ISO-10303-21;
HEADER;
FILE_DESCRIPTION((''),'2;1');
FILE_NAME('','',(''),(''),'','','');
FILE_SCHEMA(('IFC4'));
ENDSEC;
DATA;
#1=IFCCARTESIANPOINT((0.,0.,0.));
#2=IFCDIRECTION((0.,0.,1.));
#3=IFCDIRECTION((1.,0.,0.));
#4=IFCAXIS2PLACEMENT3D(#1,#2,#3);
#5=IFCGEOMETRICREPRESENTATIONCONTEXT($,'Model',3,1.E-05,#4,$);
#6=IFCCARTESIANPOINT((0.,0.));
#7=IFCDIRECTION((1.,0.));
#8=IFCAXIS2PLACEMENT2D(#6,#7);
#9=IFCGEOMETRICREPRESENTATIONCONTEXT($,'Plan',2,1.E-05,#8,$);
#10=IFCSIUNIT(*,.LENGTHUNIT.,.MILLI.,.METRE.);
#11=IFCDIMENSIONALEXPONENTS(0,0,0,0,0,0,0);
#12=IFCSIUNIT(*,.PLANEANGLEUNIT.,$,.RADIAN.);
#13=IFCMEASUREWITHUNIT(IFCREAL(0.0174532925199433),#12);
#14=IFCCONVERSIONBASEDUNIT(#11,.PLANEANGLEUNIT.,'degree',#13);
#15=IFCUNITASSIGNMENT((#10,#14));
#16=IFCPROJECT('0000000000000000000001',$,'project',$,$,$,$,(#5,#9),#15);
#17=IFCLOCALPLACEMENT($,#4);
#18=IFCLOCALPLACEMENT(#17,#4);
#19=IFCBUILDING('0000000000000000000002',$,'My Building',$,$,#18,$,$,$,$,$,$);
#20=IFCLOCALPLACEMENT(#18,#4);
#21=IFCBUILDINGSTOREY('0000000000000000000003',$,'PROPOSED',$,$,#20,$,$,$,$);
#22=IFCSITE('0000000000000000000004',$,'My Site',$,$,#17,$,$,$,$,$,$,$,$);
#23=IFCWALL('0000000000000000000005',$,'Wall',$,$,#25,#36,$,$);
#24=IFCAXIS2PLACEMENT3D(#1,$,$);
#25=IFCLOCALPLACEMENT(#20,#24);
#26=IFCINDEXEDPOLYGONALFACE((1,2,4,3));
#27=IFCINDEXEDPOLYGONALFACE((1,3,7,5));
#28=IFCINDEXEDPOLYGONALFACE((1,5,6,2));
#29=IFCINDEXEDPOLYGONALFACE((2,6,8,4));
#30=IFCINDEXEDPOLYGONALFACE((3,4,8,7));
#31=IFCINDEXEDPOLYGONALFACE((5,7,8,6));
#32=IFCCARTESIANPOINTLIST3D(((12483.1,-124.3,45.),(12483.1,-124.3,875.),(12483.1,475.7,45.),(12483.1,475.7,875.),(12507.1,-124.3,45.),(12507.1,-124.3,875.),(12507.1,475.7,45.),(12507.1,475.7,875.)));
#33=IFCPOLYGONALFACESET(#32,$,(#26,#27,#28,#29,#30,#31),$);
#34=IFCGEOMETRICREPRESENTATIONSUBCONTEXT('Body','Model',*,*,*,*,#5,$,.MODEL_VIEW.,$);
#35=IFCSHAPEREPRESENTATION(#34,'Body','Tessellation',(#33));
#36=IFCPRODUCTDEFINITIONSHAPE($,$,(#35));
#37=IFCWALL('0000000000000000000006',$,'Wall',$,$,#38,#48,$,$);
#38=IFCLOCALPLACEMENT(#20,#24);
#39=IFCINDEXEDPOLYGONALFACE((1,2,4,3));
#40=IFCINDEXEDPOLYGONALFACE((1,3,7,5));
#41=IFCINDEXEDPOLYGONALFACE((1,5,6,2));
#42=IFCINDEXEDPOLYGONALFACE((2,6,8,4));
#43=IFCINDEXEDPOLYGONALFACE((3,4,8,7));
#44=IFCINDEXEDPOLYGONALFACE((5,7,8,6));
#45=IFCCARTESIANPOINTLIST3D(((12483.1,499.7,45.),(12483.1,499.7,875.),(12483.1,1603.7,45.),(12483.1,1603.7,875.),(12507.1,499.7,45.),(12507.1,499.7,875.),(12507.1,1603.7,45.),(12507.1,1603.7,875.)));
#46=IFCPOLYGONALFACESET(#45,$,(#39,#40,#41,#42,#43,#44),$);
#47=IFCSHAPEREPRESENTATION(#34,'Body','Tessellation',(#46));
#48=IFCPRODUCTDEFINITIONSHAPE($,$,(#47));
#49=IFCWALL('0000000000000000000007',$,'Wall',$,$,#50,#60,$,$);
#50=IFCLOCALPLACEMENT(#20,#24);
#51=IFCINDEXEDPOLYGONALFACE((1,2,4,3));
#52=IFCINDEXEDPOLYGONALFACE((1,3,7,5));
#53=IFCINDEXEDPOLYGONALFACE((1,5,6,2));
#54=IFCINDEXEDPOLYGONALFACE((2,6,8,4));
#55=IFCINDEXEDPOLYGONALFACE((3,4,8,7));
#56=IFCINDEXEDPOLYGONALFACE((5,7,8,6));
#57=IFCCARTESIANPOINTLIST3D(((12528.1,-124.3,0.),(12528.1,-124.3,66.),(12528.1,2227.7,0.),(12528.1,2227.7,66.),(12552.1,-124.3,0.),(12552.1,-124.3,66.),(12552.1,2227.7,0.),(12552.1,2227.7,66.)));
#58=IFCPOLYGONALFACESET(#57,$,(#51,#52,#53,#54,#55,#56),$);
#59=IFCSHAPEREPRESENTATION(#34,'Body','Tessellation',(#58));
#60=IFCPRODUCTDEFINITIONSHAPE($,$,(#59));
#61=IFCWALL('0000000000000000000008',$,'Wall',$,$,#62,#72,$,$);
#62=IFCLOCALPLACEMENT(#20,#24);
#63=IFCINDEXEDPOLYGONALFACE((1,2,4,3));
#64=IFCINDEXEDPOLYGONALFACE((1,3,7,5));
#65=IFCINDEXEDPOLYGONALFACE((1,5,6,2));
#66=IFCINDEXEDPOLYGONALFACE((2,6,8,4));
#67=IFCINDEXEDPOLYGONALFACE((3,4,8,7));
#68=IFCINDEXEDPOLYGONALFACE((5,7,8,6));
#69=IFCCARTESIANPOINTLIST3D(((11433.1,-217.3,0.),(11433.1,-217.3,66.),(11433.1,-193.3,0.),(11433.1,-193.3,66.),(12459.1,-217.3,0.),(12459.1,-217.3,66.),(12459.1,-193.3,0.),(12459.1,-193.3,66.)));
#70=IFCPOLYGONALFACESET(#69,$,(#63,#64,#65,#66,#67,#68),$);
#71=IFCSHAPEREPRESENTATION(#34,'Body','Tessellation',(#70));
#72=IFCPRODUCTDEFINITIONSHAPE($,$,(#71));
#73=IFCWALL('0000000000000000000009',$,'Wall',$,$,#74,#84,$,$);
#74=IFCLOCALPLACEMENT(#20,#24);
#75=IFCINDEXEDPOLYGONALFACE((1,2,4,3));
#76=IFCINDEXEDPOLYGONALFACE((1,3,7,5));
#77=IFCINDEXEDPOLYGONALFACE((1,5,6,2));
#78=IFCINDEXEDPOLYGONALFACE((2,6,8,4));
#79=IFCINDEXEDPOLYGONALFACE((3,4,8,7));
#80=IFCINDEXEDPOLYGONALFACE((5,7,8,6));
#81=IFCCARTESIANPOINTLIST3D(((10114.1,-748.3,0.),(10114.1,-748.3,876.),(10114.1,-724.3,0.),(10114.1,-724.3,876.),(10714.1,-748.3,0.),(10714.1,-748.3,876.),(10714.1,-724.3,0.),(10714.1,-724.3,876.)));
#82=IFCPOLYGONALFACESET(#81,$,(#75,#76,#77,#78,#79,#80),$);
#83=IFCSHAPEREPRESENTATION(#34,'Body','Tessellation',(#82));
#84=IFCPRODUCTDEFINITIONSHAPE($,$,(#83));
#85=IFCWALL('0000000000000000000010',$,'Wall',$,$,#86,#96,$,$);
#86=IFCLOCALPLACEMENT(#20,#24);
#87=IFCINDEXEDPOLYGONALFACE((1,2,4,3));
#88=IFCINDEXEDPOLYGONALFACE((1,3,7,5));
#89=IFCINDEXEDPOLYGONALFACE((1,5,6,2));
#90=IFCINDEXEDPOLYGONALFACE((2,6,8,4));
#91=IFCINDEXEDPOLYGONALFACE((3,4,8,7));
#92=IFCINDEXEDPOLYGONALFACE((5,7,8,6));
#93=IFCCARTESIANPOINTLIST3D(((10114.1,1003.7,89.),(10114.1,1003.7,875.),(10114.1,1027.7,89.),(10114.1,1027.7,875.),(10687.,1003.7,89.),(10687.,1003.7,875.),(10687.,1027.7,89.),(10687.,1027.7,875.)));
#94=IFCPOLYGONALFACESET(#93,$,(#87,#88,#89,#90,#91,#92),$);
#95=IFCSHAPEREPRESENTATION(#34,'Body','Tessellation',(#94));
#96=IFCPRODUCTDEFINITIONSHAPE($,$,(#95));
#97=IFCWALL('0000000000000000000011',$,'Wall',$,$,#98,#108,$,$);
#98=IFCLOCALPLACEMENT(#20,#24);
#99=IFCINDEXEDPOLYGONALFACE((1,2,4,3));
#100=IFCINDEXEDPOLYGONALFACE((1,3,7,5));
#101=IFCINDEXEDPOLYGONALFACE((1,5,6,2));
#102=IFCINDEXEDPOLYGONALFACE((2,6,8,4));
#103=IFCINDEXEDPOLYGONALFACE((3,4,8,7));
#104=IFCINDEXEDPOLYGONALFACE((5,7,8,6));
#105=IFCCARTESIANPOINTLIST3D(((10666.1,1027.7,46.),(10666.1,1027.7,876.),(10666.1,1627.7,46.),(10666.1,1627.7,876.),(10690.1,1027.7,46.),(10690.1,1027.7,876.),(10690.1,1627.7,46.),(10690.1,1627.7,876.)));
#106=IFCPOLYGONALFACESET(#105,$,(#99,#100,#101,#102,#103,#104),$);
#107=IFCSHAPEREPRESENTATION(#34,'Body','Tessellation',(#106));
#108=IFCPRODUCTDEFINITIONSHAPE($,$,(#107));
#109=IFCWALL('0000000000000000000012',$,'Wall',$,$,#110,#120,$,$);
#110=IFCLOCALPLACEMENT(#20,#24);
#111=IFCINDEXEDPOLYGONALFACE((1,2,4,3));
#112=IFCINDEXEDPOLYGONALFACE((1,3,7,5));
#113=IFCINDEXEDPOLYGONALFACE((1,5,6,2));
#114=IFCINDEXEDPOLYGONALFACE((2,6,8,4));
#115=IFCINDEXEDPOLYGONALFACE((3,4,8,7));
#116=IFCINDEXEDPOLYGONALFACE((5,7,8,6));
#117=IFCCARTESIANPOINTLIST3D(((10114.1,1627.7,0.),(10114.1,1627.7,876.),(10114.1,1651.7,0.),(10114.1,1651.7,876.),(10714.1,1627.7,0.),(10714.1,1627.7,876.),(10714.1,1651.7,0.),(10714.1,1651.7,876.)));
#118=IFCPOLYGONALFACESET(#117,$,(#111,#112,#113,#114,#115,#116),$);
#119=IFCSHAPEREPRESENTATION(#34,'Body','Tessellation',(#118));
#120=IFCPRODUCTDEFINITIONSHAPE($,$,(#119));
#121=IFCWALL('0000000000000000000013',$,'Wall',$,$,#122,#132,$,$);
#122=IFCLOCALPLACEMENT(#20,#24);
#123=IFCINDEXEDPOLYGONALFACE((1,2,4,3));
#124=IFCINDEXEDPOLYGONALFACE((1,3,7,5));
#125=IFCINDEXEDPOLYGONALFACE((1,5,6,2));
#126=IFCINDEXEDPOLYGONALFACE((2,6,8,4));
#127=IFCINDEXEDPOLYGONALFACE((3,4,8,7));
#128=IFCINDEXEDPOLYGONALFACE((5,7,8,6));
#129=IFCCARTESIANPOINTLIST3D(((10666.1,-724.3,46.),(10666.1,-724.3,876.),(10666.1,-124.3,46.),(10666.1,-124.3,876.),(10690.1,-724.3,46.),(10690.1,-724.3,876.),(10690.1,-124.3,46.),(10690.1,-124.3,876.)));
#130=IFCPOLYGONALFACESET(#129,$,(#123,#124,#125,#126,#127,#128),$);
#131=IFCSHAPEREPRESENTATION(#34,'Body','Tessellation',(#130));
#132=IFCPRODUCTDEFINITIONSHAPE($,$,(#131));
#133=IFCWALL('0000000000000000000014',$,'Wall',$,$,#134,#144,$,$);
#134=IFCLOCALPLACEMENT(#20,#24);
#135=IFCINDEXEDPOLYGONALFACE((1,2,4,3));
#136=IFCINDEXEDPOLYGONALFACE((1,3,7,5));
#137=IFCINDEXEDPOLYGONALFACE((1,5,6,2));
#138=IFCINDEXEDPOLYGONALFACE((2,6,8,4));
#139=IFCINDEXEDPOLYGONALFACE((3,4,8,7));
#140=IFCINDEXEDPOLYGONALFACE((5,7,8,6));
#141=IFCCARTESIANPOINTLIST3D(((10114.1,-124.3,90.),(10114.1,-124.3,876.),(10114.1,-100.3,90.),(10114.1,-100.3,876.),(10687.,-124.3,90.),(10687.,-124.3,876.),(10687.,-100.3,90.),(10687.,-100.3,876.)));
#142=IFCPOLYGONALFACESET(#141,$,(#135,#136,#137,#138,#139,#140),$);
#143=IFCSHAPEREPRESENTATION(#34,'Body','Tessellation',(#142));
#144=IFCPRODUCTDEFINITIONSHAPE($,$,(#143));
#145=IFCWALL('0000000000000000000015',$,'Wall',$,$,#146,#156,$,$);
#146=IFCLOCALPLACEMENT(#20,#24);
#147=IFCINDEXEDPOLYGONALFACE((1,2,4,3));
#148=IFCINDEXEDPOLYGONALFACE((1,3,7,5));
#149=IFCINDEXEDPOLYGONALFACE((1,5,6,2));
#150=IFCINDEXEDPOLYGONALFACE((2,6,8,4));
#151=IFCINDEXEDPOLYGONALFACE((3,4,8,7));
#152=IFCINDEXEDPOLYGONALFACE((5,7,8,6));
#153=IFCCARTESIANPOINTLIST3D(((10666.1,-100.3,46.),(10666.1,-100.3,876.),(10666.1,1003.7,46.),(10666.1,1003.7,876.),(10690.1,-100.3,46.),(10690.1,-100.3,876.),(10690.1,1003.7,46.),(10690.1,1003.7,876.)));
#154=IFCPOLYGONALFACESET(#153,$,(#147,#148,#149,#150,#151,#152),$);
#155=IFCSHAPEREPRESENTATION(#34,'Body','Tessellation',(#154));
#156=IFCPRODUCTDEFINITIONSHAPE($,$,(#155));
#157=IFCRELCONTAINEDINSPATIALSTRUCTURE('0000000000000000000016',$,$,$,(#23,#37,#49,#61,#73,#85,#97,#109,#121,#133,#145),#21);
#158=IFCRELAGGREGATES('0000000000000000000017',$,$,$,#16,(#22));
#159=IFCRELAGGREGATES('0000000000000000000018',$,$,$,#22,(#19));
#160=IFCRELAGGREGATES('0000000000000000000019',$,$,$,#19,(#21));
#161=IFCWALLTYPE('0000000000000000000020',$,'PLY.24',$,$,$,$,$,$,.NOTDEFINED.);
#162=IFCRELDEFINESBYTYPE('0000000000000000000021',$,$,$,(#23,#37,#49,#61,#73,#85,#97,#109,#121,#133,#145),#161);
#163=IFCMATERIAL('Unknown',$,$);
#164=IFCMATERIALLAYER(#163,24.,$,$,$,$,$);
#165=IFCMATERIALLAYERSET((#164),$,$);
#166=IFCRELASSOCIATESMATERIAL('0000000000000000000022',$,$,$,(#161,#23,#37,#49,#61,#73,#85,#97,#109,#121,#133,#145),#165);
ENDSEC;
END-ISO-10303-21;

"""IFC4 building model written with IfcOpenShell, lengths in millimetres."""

from ifc_helpers import new_model, entity, si_unit, converted_unit, frame, origin_with_axes, origin_2d_with_axis, place, context, subcontext, project, spatial, indexed_curve, outline, extrude, material, layer, layer_set, layer_usage, type_object, element, save


model = new_model("IFC4")

# Units and contexts
model_context = context("Model", 3, precision=1e-05, world=origin_with_axes())
plan_context = context("Plan", 2, precision=1e-05, world=origin_2d_with_axis())
body_context = subcontext(model_context, "Body", "Model", "MODEL_VIEW")
ifc_project = project(units=[si_unit("LENGTHUNIT", "METRE", prefix="MILLI"), converted_unit("PLANEANGLEUNIT", "degree", entity("IfcReal", 0.0174532925199433), si_unit("PLANEANGLEUNIT", "RADIAN"), dimensions=[0, 0, 0, 0, 0, 0, 0])], contexts=[model_context, plan_context])

# Site, building, storey
site_placement = place(None, origin_with_axes())
site = spatial("IfcSite", under=ifc_project, at=site_placement, Name="My Site")
building_placement = place(site_placement, origin_with_axes())
building = spatial("IfcBuilding", under=site, at=building_placement, Name="My Building")
storey_placement = place(building_placement, origin_with_axes())
storey = spatial("IfcBuildingStorey", under=building, at=storey_placement, Name="PROPOSED")

# Shared definitions
ifc_material = material(Name="Unknown")

# Walls
ifc_layer_1 = layer(ifc_material, 24.0)
ifc_layer_set_1 = layer_set([ifc_layer_1])
wall_type = type_object("IfcWallType", Name="PLY.24", PredefinedType="NOTDEFINED", material=ifc_layer_set_1)
ifc_layer_usage_1 = layer_usage(ifc_layer_set_1, "AXIS2", "POSITIVE", 0.0)
wall_1_placement = place(storey_placement, frame((12483.1, 475.7, 45.0), z_axis=(0.0, 0.0, 1.0), x_axis=(0.0, -1.0, 0.0)))
element("IfcWall", 1, at=wall_1_placement, inside=storey, type_object=wall_type, material=ifc_layer_usage_1, Name="Wall", context=body_context, shape_type="SweptSolid", body=[
    extrude(outline(indexed_curve([(0.0, 0.0), (0.0, 24.0), (600.0, 24.0), (600.0, 0.0), (0.0, 0.0)], self_intersect=False)), origin_with_axes(), (0.0, 0.0, 1.0), 830.0),
])
ifc_layer_usage_2 = layer_usage(ifc_layer_set_1, "AXIS2", "POSITIVE", 0.0)
wall_2_placement = place(storey_placement, frame((12483.1, 1603.7, 45.0), z_axis=(0.0, 0.0, 1.0), x_axis=(0.0, -1.0, 0.0)))
element("IfcWall", 2, at=wall_2_placement, inside=storey, type_object=wall_type, material=ifc_layer_usage_2, Name="Wall", context=body_context, shape_type="SweptSolid", body=[
    extrude(outline(indexed_curve([(0.0, 0.0), (0.0, 24.0), (1104.0, 24.0), (1104.0, 0.0), (0.0, 0.0)], self_intersect=False)), origin_with_axes(), (0.0, 0.0, 1.0), 830.0),
])
ifc_layer_usage_3 = layer_usage(ifc_layer_set_1, "AXIS2", "POSITIVE", 0.0)
wall_3_placement = place(storey_placement, frame((12552.1, -124.3, 0.0), z_axis=(0.0, 0.0, 1.0), x_axis=(0.0, 1.0, 0.0)))
element("IfcWall", 3, at=wall_3_placement, inside=storey, type_object=wall_type, material=ifc_layer_usage_3, Name="Wall", context=body_context, shape_type="SweptSolid", body=[
    extrude(outline(indexed_curve([(0.0, 0.0), (0.0, 24.0), (2352.0, 24.0), (2352.0, 0.0), (0.0, 0.0)], self_intersect=False)), origin_with_axes(), (0.0, 0.0, 1.0), 66.0),
])
ifc_layer_usage_4 = layer_usage(ifc_layer_set_1, "AXIS2", "POSITIVE", 0.0)
wall_4_placement = place(storey_placement, frame((11433.1, -217.3, 0.0), z_axis=(0.0, 0.0, 1.0), x_axis=(1.0, 0.0, 0.0)))
element("IfcWall", 4, at=wall_4_placement, inside=storey, type_object=wall_type, material=ifc_layer_usage_4, Name="Wall", context=body_context, shape_type="SweptSolid", body=[
    extrude(outline(indexed_curve([(0.0, 0.0), (0.0, 24.0), (1026.0, 24.0), (1026.0, 0.0), (0.0, 0.0)], self_intersect=False)), origin_with_axes(), (0.0, 0.0, 1.0), 66.0),
])
ifc_layer_usage_5 = layer_usage(ifc_layer_set_1, "AXIS2", "POSITIVE", 0.0)
wall_5_placement = place(storey_placement, frame((10714.1, -724.3, 0.0), z_axis=(0.0, 0.0, 1.0), x_axis=(-1.0, 0.0, 0.0)))
element("IfcWall", 5, at=wall_5_placement, inside=storey, type_object=wall_type, material=ifc_layer_usage_5, Name="Wall", context=body_context, shape_type="SweptSolid", body=[
    extrude(outline(indexed_curve([(0.0, 0.0), (0.0, 24.0), (600.0, 24.0), (600.0, 0.0), (0.0, 0.0)], self_intersect=False)), origin_with_axes(), (0.0, 0.0, 1.0), 876.0),
])
ifc_layer_usage_6 = layer_usage(ifc_layer_set_1, "AXIS2", "POSITIVE", 0.0)
wall_6_placement = place(storey_placement, frame((10687.0, 1027.7, 89.0), z_axis=(0.0, 0.0, 1.0), x_axis=(-1.0, 0.0, 0.0)))
element("IfcWall", 6, at=wall_6_placement, inside=storey, type_object=wall_type, material=ifc_layer_usage_6, Name="Wall", context=body_context, shape_type="SweptSolid", body=[
    extrude(outline(indexed_curve([(0.0, 0.0), (0.0, 24.0), (572.9, 24.0), (572.9, 0.0), (0.0, 0.0)], self_intersect=False)), origin_with_axes(), (0.0, 0.0, 1.0), 786.0),
])
ifc_layer_usage_7 = layer_usage(ifc_layer_set_1, "AXIS2", "POSITIVE", 0.0)
wall_7_placement = place(storey_placement, frame((10690.1, 1027.7, 46.0), z_axis=(0.0, 0.0, 1.0), x_axis=(-0.000001, 1.0, 0.0)))
element("IfcWall", 7, at=wall_7_placement, inside=storey, type_object=wall_type, material=ifc_layer_usage_7, Name="Wall", context=body_context, shape_type="SweptSolid", body=[
    extrude(outline(indexed_curve([(0.0, 0.0), (0.0, 24.0), (600.0, 24.0), (600.0, 0.0), (0.0, 0.0)], self_intersect=False)), origin_with_axes(), (0.0, 0.0, 1.0), 830.0),
])
ifc_layer_usage_8 = layer_usage(ifc_layer_set_1, "AXIS2", "POSITIVE", 0.0)
wall_8_placement = place(storey_placement, frame((10714.1, 1651.7, 0.0), z_axis=(0.0, 0.0, 1.0), x_axis=(-1.0, 0.0, 0.0)))
element("IfcWall", 8, at=wall_8_placement, inside=storey, type_object=wall_type, material=ifc_layer_usage_8, Name="Wall", context=body_context, shape_type="SweptSolid", body=[
    extrude(outline(indexed_curve([(0.0, 0.0), (0.0, 24.0), (600.0, 24.0), (600.0, 0.0), (0.0, 0.0)], self_intersect=False)), origin_with_axes(), (0.0, 0.0, 1.0), 876.0),
])
ifc_layer_usage_9 = layer_usage(ifc_layer_set_1, "AXIS2", "POSITIVE", 0.0)
wall_9_placement = place(storey_placement, frame((10690.1, -724.3, 46.0), z_axis=(0.0, 0.0, 1.0), x_axis=(-0.000001, 1.0, 0.0)))
element("IfcWall", 9, at=wall_9_placement, inside=storey, type_object=wall_type, material=ifc_layer_usage_9, Name="Wall", context=body_context, shape_type="SweptSolid", body=[
    extrude(outline(indexed_curve([(0.0, 0.0), (0.0, 24.0), (600.0, 24.0), (600.0, 0.0), (0.0, 0.0)], self_intersect=False)), origin_with_axes(), (0.0, 0.0, 1.0), 830.0),
])
ifc_layer_usage_10 = layer_usage(ifc_layer_set_1, "AXIS2", "POSITIVE", 0.0)
wall_10_placement = place(storey_placement, frame((10687.0, -100.3, 90.0), z_axis=(0.0, 0.0, 1.0), x_axis=(-1.0, 0.0, 0.0)))
element("IfcWall", 10, at=wall_10_placement, inside=storey, type_object=wall_type, material=ifc_layer_usage_10, Name="Wall", context=body_context, shape_type="SweptSolid", body=[
    extrude(outline(indexed_curve([(0.0, 0.0), (0.0, 24.0), (572.9, 24.0), (572.9, 0.0), (0.0, 0.0)], self_intersect=False)), origin_with_axes(), (0.0, 0.0, 1.0), 786.0),
])
ifc_layer_usage_11 = layer_usage(ifc_layer_set_1, "AXIS2", "POSITIVE", 0.0)
wall_11_placement = place(storey_placement, frame((10690.1, -100.3, 46.0), z_axis=(0.0, 0.0, 1.0), x_axis=(-0.000001, 1.0, 0.0)))
element("IfcWall", 11, at=wall_11_placement, inside=storey, type_object=wall_type, material=ifc_layer_usage_11, Name="Wall", context=body_context, shape_type="SweptSolid", body=[
    extrude(outline(indexed_curve([(0.0, 0.0), (0.0, 24.0), (1104.0, 24.0), (1104.0, 0.0), (0.0, 0.0)], self_intersect=False)), origin_with_axes(), (0.0, 0.0, 1.0), 830.0),
])

save(model, "model.ifc")
